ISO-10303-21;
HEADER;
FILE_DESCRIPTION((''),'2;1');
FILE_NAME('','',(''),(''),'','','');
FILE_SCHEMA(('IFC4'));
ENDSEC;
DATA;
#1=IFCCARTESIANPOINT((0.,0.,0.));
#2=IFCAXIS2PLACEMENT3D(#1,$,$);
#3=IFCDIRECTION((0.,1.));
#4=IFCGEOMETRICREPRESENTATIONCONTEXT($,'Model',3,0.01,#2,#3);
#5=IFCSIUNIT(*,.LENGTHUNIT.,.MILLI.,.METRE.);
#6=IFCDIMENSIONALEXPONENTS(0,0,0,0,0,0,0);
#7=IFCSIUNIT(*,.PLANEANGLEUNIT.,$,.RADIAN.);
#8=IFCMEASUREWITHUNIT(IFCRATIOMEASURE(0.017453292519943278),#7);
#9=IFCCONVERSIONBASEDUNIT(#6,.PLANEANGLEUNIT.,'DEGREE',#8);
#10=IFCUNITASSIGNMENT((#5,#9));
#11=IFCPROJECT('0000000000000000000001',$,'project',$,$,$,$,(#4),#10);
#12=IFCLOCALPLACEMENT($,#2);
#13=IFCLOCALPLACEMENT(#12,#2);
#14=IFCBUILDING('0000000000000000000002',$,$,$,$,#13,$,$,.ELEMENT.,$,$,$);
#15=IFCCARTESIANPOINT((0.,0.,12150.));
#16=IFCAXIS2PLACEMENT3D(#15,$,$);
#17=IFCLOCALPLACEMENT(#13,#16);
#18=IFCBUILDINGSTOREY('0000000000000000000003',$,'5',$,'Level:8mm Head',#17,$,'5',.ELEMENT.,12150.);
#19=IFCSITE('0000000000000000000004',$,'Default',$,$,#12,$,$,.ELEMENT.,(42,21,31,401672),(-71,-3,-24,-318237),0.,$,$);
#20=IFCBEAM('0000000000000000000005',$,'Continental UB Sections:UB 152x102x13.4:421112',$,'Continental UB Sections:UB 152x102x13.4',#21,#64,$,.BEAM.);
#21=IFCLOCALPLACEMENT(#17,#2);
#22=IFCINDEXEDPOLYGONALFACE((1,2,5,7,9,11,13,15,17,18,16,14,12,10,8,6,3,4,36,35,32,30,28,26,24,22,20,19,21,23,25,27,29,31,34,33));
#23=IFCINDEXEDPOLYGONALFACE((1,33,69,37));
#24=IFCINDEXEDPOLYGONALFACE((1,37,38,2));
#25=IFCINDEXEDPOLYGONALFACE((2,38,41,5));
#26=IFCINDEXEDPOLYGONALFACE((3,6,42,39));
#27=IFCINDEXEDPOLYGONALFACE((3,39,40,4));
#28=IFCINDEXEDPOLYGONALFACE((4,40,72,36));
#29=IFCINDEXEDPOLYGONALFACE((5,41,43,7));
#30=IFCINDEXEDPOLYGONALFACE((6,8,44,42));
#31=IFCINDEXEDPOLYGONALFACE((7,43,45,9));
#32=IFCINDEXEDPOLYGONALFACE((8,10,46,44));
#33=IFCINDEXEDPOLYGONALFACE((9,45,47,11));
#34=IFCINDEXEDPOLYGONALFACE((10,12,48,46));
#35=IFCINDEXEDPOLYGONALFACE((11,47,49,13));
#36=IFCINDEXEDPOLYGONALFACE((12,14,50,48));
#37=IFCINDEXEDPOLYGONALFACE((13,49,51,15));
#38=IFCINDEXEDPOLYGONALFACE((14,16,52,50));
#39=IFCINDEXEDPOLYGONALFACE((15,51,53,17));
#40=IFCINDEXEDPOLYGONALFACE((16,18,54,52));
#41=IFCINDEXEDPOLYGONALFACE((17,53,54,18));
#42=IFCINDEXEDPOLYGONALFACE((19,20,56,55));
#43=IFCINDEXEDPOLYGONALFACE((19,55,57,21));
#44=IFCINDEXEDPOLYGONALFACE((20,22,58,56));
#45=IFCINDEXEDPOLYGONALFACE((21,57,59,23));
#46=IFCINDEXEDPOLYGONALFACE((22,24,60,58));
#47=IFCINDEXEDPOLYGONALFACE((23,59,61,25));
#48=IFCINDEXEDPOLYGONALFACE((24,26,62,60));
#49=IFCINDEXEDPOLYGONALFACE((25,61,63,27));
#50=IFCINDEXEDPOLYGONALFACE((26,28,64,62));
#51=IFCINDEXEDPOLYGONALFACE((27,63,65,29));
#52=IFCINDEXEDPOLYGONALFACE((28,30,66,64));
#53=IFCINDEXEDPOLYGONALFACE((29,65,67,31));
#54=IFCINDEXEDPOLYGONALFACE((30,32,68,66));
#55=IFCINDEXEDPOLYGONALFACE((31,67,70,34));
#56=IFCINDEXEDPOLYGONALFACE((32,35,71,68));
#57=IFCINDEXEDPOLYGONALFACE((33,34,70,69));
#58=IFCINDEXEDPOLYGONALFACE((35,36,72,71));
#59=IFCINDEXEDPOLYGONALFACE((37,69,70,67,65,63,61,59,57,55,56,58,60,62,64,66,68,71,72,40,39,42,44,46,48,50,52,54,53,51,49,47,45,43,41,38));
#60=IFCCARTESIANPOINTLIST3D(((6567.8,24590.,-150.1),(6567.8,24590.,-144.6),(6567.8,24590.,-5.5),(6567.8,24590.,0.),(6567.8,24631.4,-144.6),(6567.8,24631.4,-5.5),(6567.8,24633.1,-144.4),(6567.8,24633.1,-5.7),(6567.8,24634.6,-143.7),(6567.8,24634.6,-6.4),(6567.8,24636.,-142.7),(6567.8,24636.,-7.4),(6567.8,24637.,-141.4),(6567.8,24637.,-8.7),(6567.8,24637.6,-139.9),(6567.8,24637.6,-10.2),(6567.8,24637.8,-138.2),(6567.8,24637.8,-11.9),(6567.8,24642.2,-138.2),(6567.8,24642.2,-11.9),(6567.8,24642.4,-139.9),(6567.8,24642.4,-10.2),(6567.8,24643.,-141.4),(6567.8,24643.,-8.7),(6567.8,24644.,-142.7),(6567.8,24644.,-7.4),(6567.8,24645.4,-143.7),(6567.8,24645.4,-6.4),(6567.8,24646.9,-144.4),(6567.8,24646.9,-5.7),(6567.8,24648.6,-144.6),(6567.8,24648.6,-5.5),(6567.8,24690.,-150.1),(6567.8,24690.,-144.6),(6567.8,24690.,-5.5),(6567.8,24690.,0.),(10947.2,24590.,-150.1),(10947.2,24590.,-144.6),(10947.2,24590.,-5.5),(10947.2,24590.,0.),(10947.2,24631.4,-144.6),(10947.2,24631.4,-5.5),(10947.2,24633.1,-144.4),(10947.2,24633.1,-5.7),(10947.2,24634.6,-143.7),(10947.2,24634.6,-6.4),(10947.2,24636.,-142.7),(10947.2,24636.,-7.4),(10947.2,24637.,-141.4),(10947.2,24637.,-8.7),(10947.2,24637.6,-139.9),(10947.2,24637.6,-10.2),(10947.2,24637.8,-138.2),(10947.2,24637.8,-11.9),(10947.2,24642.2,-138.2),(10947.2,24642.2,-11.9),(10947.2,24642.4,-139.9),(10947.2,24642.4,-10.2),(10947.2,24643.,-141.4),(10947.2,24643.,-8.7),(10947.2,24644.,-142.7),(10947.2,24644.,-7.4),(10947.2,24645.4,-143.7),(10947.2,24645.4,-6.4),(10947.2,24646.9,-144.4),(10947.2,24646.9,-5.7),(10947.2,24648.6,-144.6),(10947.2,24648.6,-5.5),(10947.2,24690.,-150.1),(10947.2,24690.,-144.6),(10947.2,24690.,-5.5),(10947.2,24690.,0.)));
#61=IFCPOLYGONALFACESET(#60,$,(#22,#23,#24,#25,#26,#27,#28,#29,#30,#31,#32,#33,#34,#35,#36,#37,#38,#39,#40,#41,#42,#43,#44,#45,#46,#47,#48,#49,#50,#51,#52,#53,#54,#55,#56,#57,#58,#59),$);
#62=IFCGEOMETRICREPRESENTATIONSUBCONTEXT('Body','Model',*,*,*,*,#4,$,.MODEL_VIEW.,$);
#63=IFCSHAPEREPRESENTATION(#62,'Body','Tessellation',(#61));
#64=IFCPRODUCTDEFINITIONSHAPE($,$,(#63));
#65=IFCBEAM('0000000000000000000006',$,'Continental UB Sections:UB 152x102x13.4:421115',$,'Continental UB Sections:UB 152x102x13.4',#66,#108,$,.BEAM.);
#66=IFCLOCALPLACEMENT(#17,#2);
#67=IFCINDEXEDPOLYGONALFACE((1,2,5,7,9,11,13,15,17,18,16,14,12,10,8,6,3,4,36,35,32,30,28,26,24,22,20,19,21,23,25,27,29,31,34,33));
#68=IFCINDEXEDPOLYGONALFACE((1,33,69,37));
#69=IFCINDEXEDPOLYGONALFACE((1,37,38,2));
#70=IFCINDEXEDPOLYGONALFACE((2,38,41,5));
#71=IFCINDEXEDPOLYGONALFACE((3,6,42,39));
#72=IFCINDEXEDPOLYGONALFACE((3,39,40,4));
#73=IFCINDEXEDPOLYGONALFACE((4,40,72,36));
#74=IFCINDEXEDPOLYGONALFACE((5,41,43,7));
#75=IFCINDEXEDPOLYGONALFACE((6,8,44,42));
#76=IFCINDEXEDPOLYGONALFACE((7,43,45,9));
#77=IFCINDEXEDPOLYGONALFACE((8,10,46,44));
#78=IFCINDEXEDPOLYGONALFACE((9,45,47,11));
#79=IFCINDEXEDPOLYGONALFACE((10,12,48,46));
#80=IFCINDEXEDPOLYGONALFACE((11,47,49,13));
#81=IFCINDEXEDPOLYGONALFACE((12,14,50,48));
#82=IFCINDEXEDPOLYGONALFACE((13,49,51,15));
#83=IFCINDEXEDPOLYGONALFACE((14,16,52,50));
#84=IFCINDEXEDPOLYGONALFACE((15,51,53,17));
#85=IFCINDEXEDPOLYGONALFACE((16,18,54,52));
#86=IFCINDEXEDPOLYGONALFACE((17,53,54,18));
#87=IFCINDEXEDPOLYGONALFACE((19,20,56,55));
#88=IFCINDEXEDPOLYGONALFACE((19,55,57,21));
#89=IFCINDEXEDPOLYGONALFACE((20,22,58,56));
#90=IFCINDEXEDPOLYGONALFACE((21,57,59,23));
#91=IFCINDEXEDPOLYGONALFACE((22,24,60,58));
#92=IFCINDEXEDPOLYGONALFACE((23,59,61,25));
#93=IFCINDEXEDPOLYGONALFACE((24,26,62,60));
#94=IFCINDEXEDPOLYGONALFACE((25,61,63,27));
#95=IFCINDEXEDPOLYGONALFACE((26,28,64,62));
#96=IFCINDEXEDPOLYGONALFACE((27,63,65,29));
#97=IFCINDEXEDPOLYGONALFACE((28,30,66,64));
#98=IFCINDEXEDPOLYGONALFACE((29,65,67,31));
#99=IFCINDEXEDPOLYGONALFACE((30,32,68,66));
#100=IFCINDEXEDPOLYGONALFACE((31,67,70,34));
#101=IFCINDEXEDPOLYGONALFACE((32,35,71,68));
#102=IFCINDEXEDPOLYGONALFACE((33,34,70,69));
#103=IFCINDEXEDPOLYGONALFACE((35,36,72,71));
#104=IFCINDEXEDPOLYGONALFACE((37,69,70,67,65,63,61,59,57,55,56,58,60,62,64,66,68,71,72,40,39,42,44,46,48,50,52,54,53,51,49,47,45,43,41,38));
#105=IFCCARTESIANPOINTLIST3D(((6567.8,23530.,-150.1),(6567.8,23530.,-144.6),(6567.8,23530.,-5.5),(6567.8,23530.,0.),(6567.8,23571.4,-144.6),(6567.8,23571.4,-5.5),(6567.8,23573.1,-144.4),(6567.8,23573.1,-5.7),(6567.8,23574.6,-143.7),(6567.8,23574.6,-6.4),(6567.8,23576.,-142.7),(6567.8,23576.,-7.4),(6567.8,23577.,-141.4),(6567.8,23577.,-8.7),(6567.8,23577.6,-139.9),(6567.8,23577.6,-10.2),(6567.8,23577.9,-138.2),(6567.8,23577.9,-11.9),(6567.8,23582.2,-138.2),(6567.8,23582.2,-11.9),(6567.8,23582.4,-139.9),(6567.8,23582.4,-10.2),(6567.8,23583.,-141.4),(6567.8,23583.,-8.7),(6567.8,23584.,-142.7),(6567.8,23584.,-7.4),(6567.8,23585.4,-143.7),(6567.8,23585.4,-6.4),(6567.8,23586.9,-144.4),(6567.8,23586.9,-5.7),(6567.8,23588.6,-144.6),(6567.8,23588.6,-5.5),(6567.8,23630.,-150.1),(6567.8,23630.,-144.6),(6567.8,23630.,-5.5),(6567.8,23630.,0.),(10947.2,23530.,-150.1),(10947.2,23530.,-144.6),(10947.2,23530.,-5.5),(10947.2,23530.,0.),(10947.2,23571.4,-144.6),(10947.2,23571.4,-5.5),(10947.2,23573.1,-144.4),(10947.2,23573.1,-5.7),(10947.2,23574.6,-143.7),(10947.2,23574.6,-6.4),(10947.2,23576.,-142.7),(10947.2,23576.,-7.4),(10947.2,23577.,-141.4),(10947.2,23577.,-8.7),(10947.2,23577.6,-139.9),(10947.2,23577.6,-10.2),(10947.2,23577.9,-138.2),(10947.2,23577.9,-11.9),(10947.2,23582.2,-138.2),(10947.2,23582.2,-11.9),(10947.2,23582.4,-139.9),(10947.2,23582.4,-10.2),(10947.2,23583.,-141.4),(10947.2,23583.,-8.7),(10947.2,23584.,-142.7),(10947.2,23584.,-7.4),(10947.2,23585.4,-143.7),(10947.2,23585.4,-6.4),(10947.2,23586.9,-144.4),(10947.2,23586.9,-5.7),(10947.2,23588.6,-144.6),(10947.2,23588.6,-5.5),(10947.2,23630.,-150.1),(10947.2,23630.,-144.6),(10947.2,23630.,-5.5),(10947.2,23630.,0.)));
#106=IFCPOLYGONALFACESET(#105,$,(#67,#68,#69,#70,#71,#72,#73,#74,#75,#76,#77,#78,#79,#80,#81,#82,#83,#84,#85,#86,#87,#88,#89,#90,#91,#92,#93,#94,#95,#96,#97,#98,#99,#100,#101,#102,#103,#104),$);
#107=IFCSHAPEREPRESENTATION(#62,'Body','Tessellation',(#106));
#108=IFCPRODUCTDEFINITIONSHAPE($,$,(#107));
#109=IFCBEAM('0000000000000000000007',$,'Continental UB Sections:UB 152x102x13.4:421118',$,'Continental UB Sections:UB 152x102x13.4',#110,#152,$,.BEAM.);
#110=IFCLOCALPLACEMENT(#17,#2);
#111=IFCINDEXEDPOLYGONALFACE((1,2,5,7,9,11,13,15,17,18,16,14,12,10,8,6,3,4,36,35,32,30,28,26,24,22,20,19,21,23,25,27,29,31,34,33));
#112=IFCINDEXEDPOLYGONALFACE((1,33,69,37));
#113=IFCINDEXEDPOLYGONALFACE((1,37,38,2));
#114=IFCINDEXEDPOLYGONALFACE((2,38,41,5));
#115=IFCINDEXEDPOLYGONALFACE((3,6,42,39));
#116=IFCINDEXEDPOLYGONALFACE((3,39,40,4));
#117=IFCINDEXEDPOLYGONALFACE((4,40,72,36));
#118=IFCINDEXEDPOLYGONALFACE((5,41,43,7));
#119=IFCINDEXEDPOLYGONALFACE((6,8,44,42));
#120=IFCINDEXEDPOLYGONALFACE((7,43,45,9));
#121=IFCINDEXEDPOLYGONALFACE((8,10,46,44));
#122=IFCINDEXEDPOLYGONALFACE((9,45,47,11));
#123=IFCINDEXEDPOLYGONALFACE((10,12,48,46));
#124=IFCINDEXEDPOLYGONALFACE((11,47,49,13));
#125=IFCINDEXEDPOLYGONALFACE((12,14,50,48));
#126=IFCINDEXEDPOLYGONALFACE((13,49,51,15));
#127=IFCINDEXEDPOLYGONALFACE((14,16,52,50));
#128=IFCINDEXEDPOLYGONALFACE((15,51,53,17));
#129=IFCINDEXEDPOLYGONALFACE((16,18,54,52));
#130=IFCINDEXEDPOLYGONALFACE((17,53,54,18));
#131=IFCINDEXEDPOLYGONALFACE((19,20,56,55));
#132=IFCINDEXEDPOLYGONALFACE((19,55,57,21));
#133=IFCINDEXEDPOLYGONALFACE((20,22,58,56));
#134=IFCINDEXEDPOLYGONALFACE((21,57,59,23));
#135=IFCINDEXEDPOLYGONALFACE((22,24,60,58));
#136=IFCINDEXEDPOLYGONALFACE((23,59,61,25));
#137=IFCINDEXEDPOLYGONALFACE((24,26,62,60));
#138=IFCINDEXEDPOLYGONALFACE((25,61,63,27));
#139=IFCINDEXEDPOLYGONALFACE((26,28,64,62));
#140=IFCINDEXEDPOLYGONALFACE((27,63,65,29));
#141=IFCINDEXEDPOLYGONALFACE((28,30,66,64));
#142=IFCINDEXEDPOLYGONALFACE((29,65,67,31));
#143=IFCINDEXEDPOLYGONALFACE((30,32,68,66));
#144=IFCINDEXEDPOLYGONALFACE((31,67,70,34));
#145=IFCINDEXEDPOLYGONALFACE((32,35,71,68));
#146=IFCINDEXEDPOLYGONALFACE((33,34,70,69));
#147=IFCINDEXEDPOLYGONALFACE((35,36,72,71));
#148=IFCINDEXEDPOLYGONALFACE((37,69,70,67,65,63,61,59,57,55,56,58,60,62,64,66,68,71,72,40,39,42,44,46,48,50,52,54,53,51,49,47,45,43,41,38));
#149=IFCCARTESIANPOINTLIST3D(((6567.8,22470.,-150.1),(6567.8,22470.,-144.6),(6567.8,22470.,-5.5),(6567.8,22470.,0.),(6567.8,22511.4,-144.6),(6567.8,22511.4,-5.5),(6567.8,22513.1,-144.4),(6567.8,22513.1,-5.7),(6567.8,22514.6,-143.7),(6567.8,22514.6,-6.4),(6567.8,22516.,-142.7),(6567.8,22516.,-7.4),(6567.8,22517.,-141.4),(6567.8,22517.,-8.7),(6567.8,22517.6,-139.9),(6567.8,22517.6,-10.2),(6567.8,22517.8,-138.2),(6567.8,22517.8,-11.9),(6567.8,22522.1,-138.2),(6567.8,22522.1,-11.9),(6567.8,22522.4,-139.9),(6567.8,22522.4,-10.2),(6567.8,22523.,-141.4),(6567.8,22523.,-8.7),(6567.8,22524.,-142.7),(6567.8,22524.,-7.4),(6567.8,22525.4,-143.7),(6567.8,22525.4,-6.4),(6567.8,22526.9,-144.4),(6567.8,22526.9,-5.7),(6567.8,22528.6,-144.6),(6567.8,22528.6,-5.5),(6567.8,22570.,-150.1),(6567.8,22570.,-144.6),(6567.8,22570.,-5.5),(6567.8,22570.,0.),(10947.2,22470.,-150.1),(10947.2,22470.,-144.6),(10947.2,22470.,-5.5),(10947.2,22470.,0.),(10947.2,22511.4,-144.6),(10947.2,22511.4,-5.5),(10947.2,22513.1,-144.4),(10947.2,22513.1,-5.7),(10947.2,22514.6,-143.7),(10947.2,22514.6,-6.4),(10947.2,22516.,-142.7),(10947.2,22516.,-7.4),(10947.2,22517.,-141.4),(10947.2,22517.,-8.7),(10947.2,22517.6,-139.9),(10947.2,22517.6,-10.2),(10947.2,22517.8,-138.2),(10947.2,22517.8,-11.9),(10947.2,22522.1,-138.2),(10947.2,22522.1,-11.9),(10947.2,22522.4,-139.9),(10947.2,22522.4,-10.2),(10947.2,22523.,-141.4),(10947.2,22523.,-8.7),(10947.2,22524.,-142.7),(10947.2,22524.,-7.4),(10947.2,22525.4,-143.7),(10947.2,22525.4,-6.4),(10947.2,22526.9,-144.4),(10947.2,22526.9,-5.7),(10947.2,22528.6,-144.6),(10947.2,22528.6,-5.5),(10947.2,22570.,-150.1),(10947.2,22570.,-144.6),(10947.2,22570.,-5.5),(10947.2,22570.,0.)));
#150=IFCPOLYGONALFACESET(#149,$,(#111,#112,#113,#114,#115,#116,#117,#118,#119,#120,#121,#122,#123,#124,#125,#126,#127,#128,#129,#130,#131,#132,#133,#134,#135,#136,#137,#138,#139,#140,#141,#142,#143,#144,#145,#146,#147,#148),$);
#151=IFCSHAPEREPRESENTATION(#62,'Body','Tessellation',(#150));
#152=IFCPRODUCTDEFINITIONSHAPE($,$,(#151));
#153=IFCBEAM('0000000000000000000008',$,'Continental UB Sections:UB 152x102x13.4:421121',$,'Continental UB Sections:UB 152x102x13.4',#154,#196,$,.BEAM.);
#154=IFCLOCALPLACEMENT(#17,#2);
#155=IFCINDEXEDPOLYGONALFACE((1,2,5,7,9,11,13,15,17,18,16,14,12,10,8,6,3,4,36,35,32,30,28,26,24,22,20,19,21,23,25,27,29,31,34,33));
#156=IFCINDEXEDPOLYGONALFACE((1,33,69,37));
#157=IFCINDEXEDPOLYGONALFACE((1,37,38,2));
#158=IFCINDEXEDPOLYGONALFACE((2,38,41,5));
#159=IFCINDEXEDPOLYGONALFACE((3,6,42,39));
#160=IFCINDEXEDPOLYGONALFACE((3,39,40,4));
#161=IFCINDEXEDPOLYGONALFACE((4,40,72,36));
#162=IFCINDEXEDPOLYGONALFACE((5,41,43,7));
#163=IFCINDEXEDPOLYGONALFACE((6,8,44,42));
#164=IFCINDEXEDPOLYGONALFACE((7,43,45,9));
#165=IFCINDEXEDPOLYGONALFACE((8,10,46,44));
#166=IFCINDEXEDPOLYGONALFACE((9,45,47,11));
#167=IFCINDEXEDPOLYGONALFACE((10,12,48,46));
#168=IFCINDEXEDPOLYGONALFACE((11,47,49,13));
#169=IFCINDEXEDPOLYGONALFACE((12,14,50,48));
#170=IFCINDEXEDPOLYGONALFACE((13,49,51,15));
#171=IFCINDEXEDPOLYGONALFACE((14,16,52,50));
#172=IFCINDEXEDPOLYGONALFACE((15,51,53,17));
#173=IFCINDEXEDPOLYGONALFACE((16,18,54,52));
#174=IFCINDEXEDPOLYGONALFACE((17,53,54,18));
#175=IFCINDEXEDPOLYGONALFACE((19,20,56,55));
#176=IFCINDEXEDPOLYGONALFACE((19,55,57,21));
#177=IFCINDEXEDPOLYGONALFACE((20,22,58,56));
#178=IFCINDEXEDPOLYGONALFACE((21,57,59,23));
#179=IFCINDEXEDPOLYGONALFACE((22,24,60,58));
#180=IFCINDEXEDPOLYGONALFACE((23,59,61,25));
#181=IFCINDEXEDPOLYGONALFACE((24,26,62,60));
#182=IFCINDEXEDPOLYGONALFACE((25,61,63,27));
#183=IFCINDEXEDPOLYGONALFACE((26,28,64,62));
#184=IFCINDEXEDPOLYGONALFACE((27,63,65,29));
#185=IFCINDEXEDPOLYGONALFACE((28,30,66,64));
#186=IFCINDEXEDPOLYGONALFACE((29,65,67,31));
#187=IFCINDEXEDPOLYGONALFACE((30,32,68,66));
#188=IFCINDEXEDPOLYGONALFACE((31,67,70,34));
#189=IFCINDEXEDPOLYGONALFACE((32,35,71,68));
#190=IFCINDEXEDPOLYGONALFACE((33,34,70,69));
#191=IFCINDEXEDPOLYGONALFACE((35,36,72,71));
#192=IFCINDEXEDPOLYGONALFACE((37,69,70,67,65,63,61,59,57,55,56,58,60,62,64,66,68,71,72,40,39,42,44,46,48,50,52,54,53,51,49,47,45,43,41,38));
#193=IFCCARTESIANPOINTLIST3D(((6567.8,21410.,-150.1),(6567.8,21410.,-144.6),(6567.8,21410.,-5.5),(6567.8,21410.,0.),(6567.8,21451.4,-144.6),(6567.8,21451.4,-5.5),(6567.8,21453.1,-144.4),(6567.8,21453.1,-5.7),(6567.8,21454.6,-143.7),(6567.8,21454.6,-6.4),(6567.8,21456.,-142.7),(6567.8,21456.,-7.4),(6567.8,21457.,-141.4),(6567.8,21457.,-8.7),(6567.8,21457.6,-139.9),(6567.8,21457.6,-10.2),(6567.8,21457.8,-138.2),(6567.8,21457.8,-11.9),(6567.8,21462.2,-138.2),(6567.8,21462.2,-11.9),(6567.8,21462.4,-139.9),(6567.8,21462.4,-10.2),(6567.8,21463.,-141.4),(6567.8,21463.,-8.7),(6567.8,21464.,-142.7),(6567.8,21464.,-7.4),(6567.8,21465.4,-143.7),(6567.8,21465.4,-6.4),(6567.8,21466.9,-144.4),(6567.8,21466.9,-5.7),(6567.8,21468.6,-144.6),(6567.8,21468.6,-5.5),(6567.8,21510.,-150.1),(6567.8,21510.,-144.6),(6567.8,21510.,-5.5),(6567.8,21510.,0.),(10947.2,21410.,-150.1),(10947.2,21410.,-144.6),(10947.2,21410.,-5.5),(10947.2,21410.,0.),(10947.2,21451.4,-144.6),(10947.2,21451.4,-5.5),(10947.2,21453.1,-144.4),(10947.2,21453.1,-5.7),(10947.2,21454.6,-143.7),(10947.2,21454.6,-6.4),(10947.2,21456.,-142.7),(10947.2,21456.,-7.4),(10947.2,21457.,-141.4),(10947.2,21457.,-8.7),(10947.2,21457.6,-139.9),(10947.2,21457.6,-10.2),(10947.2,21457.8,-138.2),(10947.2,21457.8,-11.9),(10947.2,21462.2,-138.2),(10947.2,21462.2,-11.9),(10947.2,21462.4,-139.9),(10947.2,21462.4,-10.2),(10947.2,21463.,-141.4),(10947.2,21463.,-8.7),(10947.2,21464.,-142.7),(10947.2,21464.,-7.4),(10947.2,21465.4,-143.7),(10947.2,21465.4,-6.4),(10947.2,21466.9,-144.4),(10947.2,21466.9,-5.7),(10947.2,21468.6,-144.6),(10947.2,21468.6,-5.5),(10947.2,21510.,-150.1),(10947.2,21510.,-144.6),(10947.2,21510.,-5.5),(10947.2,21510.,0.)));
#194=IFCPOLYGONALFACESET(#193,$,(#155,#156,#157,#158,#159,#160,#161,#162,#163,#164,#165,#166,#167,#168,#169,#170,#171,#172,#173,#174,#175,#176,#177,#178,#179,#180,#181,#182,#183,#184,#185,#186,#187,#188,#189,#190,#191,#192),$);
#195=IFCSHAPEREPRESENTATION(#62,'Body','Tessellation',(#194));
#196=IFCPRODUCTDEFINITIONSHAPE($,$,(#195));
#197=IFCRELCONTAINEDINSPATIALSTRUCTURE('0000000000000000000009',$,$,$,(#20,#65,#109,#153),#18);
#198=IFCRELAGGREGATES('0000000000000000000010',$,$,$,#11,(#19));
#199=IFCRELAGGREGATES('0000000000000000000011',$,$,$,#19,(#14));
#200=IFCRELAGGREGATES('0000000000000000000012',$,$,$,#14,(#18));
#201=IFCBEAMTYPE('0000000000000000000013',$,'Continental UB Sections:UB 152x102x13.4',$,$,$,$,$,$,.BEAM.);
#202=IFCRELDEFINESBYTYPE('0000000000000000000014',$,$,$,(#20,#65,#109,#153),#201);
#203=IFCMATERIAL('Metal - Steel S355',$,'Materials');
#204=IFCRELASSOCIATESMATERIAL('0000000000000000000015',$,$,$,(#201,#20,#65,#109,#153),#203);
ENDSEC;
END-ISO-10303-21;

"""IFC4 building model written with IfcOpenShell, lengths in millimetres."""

from ifc_helpers import new_model, entity, si_unit, converted_unit, direction, frame, origin, place, context, subcontext, project, spatial, line, arc, indexed_curve, outline, extrude, source, transform, mapped, material, type_object, type_shapes, element, save


model = new_model("IFC4")

# Units and contexts
model_context = context("Model", 3, precision=0.01, world=origin(), true_north=direction((0.0, 1.0)))
body_context = subcontext(model_context, "Body", "Model", "MODEL_VIEW")
ifc_project = project(units=[si_unit("LENGTHUNIT", "METRE", prefix="MILLI"), converted_unit("PLANEANGLEUNIT", "DEGREE", entity("IfcRatioMeasure", 0.017453292519943278), si_unit("PLANEANGLEUNIT", "RADIAN"), dimensions=[0, 0, 0, 0, 0, 0, 0])], contexts=[model_context])

# Site, building, storey
site_placement = place(None, origin())
site = spatial("IfcSite", under=ifc_project, at=site_placement, Name="Default", CompositionType="ELEMENT", RefLatitude=(42, 21, 31, 401672), RefLongitude=(-71, -3, -24, -318237), RefElevation=0.0)
building_placement = place(site_placement, origin())
building = spatial("IfcBuilding", under=site, at=building_placement, CompositionType="ELEMENT")
storey_placement = place(building_placement, frame((0.0, 0.0, 12150.0)))
storey = spatial("IfcBuildingStorey", under=building, at=storey_placement, Name="5", ObjectType="Level:8mm Head", LongName="5", CompositionType="ELEMENT", Elevation=12150.0)

# Beams
ifc_material = material(Name="Metal - Steel S355", Category="Materials")
beam_type_1 = type_object("IfcBeamType", Name="Continental UB Sections:UB 152x102x13.4", PredefinedType="BEAM", material=ifc_material)
shared_shape_1 = source(origin(), body_context, "Body", "SweptSolid", [
    extrude(outline(indexed_curve([(-75.0, -50.1), (-69.6, -50.1), (-69.6, -8.5), (-67.7, -4.0), (-63.2, -2.1), (63.1, -2.1), (67.7, -4.0), (69.5, -8.5), (69.5, -50.1), (75.1, -50.1), (75.1, 50.1), (69.5, 50.1), (69.5, 8.6), (67.7, 4.0), (63.1, 2.2), (-63.2, 2.2), (-67.7, 4.0), (-69.6, 8.6), (-69.6, 50.0), (-75.0, 50.0)], segments=[line(1, 2, 3), arc(3, 4, 5), line(5, 6), arc(6, 7, 8), line(8, 9, 10, 11, 12, 13), arc(13, 14, 15), line(15, 16), arc(16, 17, 18), line(18, 19, 20, 1)], self_intersect=False)), frame((-2189.7, 0.0, 0.0), z_axis=(1.0, 0.0, 0.0), x_axis=(0.0, 0.0, -1.0)), (0.0, 0.0, 1.0), 4379.4),
])
type_shapes(beam_type_1, [shared_shape_1])
for number, where, name in (
    (1, (8757.5, 24640.0, -75.1), "Continental UB Sections:UB 152x102x13.4:421112"),
    (2, (8757.5, 23580.0, -75.1), "Continental UB Sections:UB 152x102x13.4:421115"),
    (3, (8757.5, 22520.0, -75.1), "Continental UB Sections:UB 152x102x13.4:421118"),
    (4, (8757.5, 21460.0, -75.1), "Continental UB Sections:UB 152x102x13.4:421121"),
):
    element("IfcBeam", number, at=place(storey_placement, frame(where)), inside=storey, type_object=beam_type_1, material=ifc_material, Name=name, ObjectType="Continental UB Sections:UB 152x102x13.4", PredefinedType="BEAM", context=body_context, shape_type="MappedRepresentation", body=[
        mapped(shared_shape_1, transform((0.0, 0.0, 0.0), scale=1.0)),
    ])

save(model, "model.ifc")
